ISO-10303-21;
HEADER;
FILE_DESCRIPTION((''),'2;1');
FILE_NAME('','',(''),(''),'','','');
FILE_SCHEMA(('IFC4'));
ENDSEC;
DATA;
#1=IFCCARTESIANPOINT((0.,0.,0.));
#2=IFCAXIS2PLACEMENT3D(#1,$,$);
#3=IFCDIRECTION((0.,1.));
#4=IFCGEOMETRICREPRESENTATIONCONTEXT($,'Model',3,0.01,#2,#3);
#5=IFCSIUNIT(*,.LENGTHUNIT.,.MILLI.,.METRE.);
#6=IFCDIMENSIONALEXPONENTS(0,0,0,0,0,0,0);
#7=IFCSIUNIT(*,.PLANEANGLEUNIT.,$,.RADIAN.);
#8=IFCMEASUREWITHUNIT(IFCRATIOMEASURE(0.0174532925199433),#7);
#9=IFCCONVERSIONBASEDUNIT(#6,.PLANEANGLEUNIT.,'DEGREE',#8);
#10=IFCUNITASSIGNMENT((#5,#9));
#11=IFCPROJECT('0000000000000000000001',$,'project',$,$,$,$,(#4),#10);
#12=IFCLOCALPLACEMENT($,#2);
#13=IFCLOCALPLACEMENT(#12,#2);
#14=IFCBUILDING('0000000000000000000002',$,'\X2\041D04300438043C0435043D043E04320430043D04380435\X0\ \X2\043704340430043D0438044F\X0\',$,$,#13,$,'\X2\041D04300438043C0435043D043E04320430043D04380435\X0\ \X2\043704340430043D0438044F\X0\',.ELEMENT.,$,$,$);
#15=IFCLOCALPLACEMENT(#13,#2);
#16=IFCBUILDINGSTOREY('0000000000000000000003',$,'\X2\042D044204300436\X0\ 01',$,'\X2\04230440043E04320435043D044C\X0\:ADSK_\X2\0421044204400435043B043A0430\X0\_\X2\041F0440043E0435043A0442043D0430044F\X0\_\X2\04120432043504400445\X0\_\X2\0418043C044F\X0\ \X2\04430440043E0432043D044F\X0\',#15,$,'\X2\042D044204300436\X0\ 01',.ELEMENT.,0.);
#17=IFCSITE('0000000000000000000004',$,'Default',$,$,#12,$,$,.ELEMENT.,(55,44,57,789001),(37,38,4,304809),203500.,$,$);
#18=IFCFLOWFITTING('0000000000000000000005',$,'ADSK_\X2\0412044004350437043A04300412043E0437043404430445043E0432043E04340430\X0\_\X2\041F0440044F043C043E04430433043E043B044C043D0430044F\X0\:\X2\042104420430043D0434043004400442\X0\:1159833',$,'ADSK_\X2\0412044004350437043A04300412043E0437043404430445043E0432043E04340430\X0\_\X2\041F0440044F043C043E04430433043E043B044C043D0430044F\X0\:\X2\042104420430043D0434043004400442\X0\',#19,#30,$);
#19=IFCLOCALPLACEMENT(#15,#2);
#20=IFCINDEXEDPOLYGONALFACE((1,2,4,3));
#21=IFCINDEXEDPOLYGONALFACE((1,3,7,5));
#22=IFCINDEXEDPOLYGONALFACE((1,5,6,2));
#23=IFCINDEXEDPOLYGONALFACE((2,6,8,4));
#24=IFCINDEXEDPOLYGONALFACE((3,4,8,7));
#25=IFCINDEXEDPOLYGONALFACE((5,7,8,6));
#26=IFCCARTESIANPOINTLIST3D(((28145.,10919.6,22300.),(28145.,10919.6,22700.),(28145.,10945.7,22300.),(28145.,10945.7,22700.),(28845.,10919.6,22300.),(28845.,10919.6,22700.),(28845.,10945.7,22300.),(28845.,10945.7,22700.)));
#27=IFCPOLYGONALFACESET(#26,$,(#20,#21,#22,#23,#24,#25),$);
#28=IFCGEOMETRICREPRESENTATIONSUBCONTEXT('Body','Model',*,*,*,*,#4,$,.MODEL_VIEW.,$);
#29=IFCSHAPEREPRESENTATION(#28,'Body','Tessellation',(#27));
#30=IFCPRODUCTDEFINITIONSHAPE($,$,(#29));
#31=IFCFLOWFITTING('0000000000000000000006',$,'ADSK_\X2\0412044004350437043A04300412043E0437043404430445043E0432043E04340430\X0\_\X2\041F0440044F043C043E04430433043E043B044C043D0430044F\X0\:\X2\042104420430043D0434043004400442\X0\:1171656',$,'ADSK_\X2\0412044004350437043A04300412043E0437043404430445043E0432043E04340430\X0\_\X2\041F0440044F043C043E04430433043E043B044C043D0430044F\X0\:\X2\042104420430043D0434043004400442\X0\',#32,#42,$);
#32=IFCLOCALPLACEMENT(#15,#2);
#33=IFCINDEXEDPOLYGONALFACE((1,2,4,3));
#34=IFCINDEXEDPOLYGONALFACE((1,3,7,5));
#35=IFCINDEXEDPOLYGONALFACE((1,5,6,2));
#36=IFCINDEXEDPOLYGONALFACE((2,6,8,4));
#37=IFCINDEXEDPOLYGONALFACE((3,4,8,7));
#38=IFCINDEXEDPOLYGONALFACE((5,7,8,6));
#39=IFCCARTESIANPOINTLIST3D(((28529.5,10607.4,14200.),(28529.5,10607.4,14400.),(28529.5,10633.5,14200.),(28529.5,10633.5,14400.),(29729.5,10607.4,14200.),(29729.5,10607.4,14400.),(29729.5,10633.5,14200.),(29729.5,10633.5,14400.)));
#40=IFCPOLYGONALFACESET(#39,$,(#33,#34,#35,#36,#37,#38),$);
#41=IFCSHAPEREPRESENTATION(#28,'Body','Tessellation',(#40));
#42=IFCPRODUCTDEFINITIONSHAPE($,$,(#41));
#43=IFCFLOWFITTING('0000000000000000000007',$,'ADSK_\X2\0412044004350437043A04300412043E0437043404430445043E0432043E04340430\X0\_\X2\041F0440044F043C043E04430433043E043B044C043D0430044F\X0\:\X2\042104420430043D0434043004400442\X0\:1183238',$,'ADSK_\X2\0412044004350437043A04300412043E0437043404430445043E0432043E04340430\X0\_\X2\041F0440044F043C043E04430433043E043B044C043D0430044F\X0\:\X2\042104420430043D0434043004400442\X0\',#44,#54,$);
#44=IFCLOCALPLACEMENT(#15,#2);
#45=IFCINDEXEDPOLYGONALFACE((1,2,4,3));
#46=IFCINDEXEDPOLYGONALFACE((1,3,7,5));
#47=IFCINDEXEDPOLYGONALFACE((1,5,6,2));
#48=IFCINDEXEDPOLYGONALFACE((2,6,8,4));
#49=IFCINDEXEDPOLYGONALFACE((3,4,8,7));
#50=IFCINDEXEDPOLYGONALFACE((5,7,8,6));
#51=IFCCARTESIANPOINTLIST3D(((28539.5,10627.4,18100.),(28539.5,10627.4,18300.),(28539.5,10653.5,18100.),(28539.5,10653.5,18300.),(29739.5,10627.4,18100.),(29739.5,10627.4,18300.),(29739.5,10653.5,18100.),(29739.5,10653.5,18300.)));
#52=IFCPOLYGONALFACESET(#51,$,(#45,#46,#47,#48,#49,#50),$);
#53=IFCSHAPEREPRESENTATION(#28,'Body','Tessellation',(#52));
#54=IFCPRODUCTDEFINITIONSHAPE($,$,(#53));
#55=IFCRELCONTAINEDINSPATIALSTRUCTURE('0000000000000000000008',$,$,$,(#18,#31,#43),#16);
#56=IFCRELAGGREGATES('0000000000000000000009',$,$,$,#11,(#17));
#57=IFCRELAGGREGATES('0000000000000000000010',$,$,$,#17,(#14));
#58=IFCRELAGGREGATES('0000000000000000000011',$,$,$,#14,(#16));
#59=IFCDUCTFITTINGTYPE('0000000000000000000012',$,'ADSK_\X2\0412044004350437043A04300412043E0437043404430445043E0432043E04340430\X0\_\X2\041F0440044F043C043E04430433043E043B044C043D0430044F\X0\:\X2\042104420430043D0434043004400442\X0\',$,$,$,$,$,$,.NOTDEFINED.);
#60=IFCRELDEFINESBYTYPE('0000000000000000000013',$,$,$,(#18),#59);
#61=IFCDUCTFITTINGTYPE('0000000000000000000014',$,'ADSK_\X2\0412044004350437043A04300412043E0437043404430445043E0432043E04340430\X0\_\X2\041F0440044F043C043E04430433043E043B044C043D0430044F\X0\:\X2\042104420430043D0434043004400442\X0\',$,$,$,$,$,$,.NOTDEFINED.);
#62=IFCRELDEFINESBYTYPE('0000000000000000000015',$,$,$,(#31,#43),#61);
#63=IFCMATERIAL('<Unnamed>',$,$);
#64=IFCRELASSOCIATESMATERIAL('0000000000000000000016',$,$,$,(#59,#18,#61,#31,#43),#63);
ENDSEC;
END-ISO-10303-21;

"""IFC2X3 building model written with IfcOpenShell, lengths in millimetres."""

from ifc_helpers import new_model, entity, si_unit, converted_unit, direction, frame, origin, origin_2d_with_axis, place, context, subcontext, project, spatial, rectangle, extrude, source, transform, mapped, material, type_object, type_shapes, element, save


model = new_model("IFC2X3")

# Units and contexts
model_context = context("Model", 3, precision=0.01, world=origin(), true_north=direction((0.0, 1.0)))
body_context = subcontext(model_context, "Body", "Model", "MODEL_VIEW")
ifc_project = project(units=[si_unit("LENGTHUNIT", "METRE", prefix="MILLI"), converted_unit("PLANEANGLEUNIT", "DEGREE", entity("IfcRatioMeasure", 0.0174532925199433), si_unit("PLANEANGLEUNIT", "RADIAN"), dimensions=[0, 0, 0, 0, 0, 0, 0])], contexts=[model_context])

# Site, building, storey
site_placement = place(None, origin())
site = spatial("IfcSite", under=ifc_project, at=site_placement, Name="Default", CompositionType="ELEMENT", RefLatitude=(55, 44, 57, 789001), RefLongitude=(37, 38, 4, 304809), RefElevation=203500.0)
building_placement = place(site_placement, origin())
building = spatial("IfcBuilding", under=site, at=building_placement, Name="Наименование здания", LongName="Наименование здания", CompositionType="ELEMENT")
storey_placement = place(building_placement, origin())
storey = spatial("IfcBuildingStorey", under=building, at=storey_placement, Name="Этаж 01", ObjectType="Уровень:ADSK_Стрелка_Проектная_Вверх_Имя уровня", LongName="Этаж 01", CompositionType="ELEMENT", Elevation=0.0)

# Shared definitions
ifc_material_1 = material(Name="<Unnamed>")

# Flow fittings
duct_fitting_type_1 = type_object("IfcDuctFittingType", Name="ADSK_ВрезкаВоздуховода_Прямоугольная:Стандарт", PredefinedType="NOTDEFINED", material=ifc_material_1)
shared_shape_1 = source(origin(), body_context, "Body", "SweptSolid", [
    extrude(rectangle(XDim=700.0, YDim=26.1, at=origin_2d_with_axis()), frame((7.0, 0.0, -200.0), z_axis=(0.0, 0.0, 1.0), x_axis=(0.0, -1.0, 0.0)), (0.0, 0.0, 1.0), 400.0),
])
type_shapes(duct_fitting_type_1, [shared_shape_1])
flow_fitting_1_placement = place(storey_placement, frame((28495.0, 10939.6, 22500.0), z_axis=(0.0, 0.0, -1.0), x_axis=(0.0, -1.0, 0.0)))
element("IfcFlowFitting", 1, at=flow_fitting_1_placement, inside=storey, type_object=duct_fitting_type_1, material=ifc_material_1, Name="ADSK_ВрезкаВоздуховода_Прямоугольная:Стандарт:1159833", ObjectType="ADSK_ВрезкаВоздуховода_Прямоугольная:Стандарт", context=body_context, shape_type="MappedRepresentation", body=[
    mapped(shared_shape_1, transform((0.0, 0.0, 0.0), scale=1.0)),
])
duct_fitting_type_2 = type_object("IfcDuctFittingType", Name="ADSK_ВрезкаВоздуховода_Прямоугольная:Стандарт", PredefinedType="NOTDEFINED", material=ifc_material_1)
shared_shape_2 = source(origin(), body_context, "Body", "SweptSolid", [
    extrude(rectangle(XDim=26.1, YDim=1200.0, at=origin_2d_with_axis()), frame((7.0, 0.0, -100.0)), (0.0, 0.0, 1.0), 200.0),
])
type_shapes(duct_fitting_type_2, [shared_shape_2])
for number, where, z_axis, x_axis, name in (
    (2, (29129.5, 10627.4, 14300.0), (0.0, 0.0, -1.0), (0.0, -1.0, 0.0), "ADSK_ВрезкаВоздуховода_Прямоугольная:Стандарт:1171656"),
    (3, (29139.5, 10647.4, 18200.0), (0.0, 0.0, 1.0), (0.0, -1.0, 0.0), "ADSK_ВрезкаВоздуховода_Прямоугольная:Стандарт:1183238"),
):
    element("IfcFlowFitting", number, at=place(storey_placement, frame(where, z_axis=z_axis, x_axis=x_axis)), inside=storey, type_object=duct_fitting_type_2, material=ifc_material_1, Name=name, ObjectType="ADSK_ВрезкаВоздуховода_Прямоугольная:Стандарт", context=body_context, shape_type="MappedRepresentation", body=[
        mapped(shared_shape_2, transform((0.0, 0.0, 0.0), scale=1.0)),
    ])

save(model, "model.ifc")
